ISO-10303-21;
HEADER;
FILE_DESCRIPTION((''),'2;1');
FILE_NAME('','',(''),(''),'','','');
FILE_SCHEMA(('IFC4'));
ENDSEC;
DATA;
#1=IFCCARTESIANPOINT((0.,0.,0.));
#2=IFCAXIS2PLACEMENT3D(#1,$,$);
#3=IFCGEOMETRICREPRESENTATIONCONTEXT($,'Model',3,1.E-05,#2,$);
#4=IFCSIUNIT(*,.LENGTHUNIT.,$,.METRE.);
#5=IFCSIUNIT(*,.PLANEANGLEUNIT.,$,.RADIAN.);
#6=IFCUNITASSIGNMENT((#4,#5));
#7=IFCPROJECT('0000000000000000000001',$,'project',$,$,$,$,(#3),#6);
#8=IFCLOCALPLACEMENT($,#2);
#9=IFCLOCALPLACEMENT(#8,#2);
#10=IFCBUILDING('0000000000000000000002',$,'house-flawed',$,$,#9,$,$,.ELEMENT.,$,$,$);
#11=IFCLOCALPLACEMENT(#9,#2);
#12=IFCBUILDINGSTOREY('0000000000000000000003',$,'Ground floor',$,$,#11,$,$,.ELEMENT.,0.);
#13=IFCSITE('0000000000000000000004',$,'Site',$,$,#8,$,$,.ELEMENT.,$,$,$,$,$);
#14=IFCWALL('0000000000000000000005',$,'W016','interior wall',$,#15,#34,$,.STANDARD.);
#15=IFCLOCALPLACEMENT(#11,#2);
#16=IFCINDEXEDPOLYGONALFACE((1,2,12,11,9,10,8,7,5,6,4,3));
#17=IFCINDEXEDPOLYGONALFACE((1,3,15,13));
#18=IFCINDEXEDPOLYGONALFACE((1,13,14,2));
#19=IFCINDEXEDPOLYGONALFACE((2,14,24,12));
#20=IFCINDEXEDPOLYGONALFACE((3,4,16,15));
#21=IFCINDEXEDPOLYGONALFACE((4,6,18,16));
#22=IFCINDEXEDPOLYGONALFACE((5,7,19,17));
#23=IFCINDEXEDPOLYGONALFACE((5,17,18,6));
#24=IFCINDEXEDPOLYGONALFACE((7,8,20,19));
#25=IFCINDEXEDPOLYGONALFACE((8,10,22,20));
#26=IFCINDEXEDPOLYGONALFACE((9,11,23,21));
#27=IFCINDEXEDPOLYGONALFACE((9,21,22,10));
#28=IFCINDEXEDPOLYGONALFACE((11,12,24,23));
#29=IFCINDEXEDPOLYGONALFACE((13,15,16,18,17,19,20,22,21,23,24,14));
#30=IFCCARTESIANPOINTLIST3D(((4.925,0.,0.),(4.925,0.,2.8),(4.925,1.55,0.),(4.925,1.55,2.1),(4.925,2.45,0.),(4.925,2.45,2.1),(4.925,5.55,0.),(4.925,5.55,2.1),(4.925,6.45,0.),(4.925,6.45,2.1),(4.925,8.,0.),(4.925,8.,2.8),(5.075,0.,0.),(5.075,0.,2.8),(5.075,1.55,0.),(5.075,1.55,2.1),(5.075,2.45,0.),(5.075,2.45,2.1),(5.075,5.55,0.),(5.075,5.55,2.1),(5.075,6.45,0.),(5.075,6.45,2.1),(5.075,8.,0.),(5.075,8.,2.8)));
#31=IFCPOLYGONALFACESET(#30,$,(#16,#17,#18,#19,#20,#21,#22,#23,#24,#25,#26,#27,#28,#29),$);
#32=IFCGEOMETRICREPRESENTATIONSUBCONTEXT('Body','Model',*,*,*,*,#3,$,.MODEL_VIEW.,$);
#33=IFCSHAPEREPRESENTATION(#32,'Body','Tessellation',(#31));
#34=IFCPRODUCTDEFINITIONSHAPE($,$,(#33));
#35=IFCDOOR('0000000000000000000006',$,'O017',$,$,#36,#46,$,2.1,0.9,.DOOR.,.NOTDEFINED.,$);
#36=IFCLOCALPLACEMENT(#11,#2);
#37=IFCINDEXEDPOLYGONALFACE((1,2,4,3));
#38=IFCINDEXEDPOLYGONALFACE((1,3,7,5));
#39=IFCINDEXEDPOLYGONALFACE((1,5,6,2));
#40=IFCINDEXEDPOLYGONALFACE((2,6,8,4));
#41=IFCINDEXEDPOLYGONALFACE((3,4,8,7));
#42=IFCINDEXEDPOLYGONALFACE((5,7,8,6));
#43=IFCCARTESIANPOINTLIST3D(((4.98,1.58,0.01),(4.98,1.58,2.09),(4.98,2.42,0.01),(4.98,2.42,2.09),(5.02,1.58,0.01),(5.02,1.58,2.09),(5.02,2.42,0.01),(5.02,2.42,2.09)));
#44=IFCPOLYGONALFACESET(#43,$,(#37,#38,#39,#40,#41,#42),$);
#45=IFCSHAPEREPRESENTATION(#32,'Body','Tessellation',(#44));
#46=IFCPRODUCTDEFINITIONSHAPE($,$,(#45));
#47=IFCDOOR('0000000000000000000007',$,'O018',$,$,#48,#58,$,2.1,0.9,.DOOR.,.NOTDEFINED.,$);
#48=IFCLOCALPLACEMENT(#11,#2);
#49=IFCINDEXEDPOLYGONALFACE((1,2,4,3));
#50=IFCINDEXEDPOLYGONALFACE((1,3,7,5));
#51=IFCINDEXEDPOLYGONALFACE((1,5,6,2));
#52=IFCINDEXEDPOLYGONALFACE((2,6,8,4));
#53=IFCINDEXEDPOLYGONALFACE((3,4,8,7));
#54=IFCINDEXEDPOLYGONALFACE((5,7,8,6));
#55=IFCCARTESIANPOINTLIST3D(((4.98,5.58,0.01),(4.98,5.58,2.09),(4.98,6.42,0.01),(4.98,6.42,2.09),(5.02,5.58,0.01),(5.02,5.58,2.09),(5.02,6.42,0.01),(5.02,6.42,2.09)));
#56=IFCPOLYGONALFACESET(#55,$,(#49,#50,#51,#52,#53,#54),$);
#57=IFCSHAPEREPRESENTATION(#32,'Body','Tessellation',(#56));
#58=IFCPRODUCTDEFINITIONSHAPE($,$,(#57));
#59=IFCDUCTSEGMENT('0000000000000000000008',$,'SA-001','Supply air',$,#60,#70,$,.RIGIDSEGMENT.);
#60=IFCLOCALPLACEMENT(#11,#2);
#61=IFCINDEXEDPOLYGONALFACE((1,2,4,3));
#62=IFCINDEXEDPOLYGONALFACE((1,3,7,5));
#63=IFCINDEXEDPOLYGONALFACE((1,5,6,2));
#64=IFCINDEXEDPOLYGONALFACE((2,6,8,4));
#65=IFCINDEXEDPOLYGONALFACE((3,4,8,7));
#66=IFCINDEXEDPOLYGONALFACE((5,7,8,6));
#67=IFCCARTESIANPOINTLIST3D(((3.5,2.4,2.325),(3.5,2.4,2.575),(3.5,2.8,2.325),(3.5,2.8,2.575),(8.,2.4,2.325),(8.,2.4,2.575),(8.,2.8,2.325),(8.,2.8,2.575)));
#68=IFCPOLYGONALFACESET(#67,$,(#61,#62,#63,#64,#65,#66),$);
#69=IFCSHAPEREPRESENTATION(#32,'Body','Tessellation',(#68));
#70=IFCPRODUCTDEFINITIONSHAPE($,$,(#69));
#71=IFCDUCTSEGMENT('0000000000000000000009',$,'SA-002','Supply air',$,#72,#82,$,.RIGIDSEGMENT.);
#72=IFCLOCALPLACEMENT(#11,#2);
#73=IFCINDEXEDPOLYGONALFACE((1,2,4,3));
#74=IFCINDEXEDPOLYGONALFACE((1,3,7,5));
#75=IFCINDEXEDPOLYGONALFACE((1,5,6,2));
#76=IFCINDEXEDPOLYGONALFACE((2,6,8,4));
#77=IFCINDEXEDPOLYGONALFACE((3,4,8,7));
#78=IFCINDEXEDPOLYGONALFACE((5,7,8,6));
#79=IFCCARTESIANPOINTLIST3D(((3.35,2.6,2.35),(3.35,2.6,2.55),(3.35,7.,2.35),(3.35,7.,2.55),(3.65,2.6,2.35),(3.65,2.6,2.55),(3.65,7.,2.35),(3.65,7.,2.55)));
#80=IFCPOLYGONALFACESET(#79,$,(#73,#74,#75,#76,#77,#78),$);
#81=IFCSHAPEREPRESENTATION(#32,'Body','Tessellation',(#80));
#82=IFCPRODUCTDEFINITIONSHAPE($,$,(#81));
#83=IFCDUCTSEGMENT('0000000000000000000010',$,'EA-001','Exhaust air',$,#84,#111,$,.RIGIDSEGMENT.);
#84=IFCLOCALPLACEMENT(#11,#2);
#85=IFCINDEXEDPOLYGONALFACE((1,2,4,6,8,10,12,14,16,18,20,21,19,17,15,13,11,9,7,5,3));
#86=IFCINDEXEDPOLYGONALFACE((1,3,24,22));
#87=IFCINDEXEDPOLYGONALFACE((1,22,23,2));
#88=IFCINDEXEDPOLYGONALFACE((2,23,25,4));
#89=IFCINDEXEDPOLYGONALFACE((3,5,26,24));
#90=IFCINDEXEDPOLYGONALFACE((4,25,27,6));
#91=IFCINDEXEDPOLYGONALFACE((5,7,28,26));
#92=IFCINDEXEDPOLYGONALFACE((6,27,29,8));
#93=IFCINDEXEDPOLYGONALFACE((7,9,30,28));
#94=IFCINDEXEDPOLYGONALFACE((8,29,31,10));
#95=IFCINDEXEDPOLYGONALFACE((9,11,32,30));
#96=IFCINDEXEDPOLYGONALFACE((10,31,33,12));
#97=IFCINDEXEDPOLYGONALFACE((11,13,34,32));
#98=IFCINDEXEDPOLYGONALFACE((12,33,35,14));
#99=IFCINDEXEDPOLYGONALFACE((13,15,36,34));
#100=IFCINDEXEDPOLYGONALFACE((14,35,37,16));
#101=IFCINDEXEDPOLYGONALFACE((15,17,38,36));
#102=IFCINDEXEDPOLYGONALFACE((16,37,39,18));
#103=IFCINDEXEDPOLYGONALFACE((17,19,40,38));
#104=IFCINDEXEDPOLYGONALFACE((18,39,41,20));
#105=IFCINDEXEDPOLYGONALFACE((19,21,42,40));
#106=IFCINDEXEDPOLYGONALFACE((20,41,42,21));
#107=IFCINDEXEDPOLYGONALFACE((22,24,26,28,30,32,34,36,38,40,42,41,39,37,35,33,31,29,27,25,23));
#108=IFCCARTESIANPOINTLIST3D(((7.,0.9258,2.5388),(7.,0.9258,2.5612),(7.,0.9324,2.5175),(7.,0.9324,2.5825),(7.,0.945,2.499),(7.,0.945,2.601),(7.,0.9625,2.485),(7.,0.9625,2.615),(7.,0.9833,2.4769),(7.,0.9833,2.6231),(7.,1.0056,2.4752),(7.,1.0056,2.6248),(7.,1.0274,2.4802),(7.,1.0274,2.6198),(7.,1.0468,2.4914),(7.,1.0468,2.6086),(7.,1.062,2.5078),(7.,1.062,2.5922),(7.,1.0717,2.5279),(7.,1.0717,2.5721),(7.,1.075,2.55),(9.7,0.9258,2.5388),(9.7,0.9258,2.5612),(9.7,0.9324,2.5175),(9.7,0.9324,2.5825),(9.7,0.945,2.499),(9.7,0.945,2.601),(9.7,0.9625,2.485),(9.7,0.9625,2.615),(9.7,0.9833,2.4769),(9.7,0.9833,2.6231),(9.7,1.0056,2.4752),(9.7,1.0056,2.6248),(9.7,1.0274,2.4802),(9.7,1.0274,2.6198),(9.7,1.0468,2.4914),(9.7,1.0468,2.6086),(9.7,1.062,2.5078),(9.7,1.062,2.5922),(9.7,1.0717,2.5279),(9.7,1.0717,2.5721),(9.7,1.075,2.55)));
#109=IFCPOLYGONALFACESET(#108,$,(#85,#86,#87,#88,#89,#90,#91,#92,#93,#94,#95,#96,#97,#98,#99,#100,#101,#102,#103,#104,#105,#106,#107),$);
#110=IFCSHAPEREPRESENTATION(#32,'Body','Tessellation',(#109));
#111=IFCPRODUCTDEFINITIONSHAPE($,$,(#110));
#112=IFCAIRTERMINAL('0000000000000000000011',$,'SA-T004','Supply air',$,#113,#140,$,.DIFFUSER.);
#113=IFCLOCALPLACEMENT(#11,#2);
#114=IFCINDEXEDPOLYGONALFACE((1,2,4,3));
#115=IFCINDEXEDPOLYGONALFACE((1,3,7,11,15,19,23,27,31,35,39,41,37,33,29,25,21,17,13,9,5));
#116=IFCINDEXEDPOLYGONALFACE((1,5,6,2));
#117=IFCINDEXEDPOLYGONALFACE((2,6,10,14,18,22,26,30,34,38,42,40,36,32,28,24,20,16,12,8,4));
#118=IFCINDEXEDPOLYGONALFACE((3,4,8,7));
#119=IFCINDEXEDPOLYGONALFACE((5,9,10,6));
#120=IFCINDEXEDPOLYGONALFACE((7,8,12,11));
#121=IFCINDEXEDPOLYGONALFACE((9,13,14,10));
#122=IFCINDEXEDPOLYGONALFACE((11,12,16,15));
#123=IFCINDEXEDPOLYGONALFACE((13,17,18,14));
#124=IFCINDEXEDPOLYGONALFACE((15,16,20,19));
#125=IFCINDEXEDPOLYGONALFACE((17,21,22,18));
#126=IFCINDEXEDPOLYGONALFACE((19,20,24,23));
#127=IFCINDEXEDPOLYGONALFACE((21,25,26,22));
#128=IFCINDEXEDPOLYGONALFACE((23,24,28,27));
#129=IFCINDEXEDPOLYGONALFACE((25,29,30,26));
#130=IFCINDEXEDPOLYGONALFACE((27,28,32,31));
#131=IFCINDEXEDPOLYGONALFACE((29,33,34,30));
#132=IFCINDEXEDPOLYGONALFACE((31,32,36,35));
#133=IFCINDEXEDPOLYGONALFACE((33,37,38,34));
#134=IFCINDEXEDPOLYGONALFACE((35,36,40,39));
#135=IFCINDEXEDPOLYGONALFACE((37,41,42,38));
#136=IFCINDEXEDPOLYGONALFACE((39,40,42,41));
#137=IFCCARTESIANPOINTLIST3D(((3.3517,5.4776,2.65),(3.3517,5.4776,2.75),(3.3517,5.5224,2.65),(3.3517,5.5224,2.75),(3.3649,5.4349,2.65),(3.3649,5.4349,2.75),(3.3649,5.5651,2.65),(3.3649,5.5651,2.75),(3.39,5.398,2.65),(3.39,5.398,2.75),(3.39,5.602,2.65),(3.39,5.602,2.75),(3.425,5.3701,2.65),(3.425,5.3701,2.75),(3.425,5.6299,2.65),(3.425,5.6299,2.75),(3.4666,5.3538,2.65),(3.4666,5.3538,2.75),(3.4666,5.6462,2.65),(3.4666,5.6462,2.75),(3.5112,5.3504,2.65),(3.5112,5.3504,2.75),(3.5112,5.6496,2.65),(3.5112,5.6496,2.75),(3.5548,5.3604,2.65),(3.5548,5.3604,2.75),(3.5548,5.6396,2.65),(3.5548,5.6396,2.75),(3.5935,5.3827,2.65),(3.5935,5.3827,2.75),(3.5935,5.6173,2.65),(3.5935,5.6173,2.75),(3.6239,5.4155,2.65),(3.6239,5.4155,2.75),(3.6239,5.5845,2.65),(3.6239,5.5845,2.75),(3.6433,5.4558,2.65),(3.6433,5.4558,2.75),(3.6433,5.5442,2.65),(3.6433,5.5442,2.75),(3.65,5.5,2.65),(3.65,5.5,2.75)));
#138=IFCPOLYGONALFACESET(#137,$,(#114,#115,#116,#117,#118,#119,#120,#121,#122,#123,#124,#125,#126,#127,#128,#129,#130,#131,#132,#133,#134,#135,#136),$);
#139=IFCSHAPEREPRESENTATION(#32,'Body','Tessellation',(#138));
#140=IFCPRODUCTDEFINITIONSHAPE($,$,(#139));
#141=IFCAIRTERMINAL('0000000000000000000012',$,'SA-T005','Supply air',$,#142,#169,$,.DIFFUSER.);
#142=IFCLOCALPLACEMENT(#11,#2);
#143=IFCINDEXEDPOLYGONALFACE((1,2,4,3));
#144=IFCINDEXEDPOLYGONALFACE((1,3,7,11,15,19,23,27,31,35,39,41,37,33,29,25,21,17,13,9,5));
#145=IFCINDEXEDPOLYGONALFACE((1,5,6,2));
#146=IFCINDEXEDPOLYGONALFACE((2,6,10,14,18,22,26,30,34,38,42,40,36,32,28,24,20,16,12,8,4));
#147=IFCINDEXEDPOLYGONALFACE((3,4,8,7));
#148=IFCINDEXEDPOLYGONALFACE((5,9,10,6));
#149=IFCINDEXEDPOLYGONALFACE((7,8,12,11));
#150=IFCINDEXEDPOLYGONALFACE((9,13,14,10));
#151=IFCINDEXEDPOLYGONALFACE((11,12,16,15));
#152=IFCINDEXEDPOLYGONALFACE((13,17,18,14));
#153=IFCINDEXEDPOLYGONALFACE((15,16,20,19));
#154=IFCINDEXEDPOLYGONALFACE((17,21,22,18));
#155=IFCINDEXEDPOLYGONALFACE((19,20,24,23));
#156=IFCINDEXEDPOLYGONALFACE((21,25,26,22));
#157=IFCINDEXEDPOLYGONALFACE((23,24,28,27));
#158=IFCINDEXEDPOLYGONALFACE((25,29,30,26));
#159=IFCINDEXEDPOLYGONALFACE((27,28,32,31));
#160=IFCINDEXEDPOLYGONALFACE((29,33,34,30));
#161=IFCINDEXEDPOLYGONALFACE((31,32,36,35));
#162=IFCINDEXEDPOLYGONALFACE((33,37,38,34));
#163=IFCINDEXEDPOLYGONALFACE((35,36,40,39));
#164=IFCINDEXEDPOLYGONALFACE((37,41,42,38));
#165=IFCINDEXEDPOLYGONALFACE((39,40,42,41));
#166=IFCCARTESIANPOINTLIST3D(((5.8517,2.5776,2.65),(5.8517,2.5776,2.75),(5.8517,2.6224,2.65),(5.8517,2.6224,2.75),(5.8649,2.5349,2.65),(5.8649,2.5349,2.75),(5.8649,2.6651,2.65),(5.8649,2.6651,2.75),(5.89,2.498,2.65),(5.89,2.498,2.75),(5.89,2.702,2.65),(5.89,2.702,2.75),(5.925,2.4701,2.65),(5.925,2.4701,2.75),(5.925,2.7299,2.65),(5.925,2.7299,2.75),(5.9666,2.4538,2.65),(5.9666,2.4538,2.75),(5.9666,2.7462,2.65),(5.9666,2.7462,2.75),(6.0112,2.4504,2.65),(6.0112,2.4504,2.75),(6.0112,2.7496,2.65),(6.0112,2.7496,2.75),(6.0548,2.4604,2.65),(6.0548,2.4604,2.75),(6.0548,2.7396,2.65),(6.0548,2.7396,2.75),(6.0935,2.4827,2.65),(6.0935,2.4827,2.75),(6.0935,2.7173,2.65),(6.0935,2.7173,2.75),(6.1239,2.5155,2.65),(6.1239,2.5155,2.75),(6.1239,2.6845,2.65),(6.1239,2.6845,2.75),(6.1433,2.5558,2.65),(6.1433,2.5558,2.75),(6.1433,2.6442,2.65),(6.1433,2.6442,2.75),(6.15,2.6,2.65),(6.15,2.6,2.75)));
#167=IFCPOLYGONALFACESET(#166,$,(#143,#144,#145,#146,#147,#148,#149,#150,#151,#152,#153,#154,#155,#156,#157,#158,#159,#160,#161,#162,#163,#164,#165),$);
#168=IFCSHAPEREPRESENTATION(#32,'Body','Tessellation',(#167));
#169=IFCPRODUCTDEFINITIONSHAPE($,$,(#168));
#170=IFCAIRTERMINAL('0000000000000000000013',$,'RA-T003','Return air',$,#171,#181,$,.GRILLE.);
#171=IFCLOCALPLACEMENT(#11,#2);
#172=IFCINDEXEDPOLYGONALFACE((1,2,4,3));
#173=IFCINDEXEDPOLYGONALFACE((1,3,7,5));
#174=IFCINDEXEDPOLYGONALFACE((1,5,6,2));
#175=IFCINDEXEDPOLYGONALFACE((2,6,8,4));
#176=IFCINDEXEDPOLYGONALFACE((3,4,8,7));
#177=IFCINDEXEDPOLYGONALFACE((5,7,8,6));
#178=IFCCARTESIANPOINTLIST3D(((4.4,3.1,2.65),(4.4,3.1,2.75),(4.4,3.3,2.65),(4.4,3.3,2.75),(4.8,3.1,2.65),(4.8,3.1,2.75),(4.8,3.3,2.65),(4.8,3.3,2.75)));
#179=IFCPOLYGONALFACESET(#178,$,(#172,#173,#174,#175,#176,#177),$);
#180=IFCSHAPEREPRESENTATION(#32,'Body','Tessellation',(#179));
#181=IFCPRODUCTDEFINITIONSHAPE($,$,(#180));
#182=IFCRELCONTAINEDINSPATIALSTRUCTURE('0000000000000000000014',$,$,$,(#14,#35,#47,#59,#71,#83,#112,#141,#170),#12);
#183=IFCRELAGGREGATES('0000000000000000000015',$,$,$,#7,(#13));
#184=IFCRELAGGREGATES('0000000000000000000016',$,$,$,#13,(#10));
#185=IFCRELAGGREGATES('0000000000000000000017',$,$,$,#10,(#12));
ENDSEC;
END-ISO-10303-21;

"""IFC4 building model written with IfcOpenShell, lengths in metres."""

from ifc_helpers import new_model, si_unit, frame, origin, origin_2d, place, context, subcontext, project, spatial, rectangle, circle, extrude, element, fill, save


model = new_model("IFC4")

# Units and contexts
model_context = context("Model", 3, precision=1e-05, world=origin())
body_context = subcontext(model_context, "Body", "Model", "MODEL_VIEW")
ifc_project = project(units=[si_unit("LENGTHUNIT", "METRE"), si_unit("PLANEANGLEUNIT", "RADIAN")], contexts=[model_context])

# Site, building, storey
site_placement = place(None, origin())
site = spatial("IfcSite", under=ifc_project, at=site_placement, Name="Site", CompositionType="ELEMENT")
building_placement = place(site_placement, origin())
building = spatial("IfcBuilding", under=site, at=building_placement, Name="house-flawed", CompositionType="ELEMENT")
storey_placement = place(building_placement, origin())
storey = spatial("IfcBuildingStorey", under=building, at=storey_placement, Name="Ground floor", CompositionType="ELEMENT", Elevation=0.0)

# Wall, openings, doors
wall_1_placement = place(storey_placement, frame((5.0, 4.0, 0.0), z_axis=(0.0, 0.0, 1.0), x_axis=(0.0, 1.0, 0.0)))
wall_1 = element("IfcWall", 1, at=wall_1_placement, inside=storey, Name="W016", Description="interior wall", PredefinedType="STANDARD", context=body_context, shape_type="SweptSolid", body=[
    extrude(rectangle(XDim=8.0, YDim=0.15, at=origin_2d()), origin(), (0.0, 0.0, 1.0), 2.8),
])
opening_1_placement = place(wall_1_placement, frame((-2.0, 0.0, 0.0)))
opening_1 = element("IfcOpeningElement", 2, at=opening_1_placement, cuts=wall_1, PredefinedType="OPENING", context=body_context, shape_type="SweptSolid", body=[
    extrude(rectangle(XDim=0.9, YDim=0.18, at=origin_2d()), origin(), (0.0, 0.0, 1.0), 2.1),
])
opening_2_placement = place(wall_1_placement, frame((2.0, 0.0, 0.0)))
opening_2 = element("IfcOpeningElement", 3, at=opening_2_placement, cuts=wall_1, PredefinedType="OPENING", context=body_context, shape_type="SweptSolid", body=[
    extrude(rectangle(XDim=0.9, YDim=0.18, at=origin_2d()), origin(), (0.0, 0.0, 1.0), 2.1),
])
door_1_placement = place(wall_1_placement, frame((-2.0, 0.0, 0.0)))
door_1 = element("IfcDoor", 4, at=door_1_placement, inside=storey, Name="O017", OperationType="NOTDEFINED", OverallHeight=2.1, OverallWidth=0.9, PredefinedType="DOOR", context=body_context, shape_type="SweptSolid", body=[
    extrude(rectangle(XDim=0.84, YDim=0.04, at=origin_2d()), frame((0.0, 0.0, 0.01)), (0.0, 0.0, 1.0), 2.08),
])
fill(opening_1, door_1)
door_2_placement = place(wall_1_placement, frame((2.0, 0.0, 0.0)))
door_2 = element("IfcDoor", 5, at=door_2_placement, inside=storey, Name="O018", OperationType="NOTDEFINED", OverallHeight=2.1, OverallWidth=0.9, PredefinedType="DOOR", context=body_context, shape_type="SweptSolid", body=[
    extrude(rectangle(XDim=0.84, YDim=0.04, at=origin_2d()), frame((0.0, 0.0, 0.01)), (0.0, 0.0, 1.0), 2.08),
])
fill(opening_2, door_2)

# Duct segments
duct_segment_1_placement = place(storey_placement, frame((3.5, 2.6, 2.45), z_axis=(1.0, 0.0, 0.0), x_axis=(0.0, 1.0, 0.0)))
element("IfcDuctSegment", 6, at=duct_segment_1_placement, inside=storey, Name="SA-001", Description="Supply air", PredefinedType="RIGIDSEGMENT", context=body_context, shape_type="SweptSolid", body=[
    extrude(rectangle(XDim=0.4, YDim=0.25, at=origin_2d()), origin(), (0.0, 0.0, 1.0), 4.5),
])
duct_segment_2_placement = place(storey_placement, frame((3.5, 2.6, 2.45), z_axis=(0.0, 1.0, 0.0), x_axis=(-1.0, 0.0, 0.0)))
element("IfcDuctSegment", 7, at=duct_segment_2_placement, inside=storey, Name="SA-002", Description="Supply air", PredefinedType="RIGIDSEGMENT", context=body_context, shape_type="SweptSolid", body=[
    extrude(rectangle(XDim=0.3, YDim=0.2, at=origin_2d()), origin(), (0.0, 0.0, 1.0), 4.4),
])
duct_segment_3_placement = place(storey_placement, frame((7.0, 1.0, 2.55), z_axis=(1.0, 0.0, 0.0), x_axis=(0.0, 1.0, 0.0)))
element("IfcDuctSegment", 8, at=duct_segment_3_placement, inside=storey, Name="EA-001", Description="Exhaust air", PredefinedType="RIGIDSEGMENT", context=body_context, shape_type="SweptSolid", body=[
    extrude(circle(Radius=0.075, at=origin_2d()), origin(), (0.0, 0.0, 1.0), 2.7),
])

# Air terminals
for number, where, z_axis, x_axis, name in (
    (9, (3.5, 5.5, 2.65), (0.0, 0.0, 1.0), (1.0, 0.0, 0.0), "SA-T004"),
    (10, (6.0, 2.6, 2.65), (0.0, 0.0, 1.0), (1.0, 0.0, 0.0), "SA-T005"),
):
    element("IfcAirTerminal", number, at=place(storey_placement, frame(where, z_axis=z_axis, x_axis=x_axis)), inside=storey, Name=name, Description="Supply air", PredefinedType="DIFFUSER", context=body_context, shape_type="SweptSolid", body=[
        extrude(circle(Radius=0.15, at=origin_2d()), origin(), (0.0, 0.0, 1.0), 0.1),
    ])
air_terminal_placement = place(storey_placement, frame((4.6, 3.2, 2.65), z_axis=(0.0, 0.0, 1.0), x_axis=(1.0, 0.0, 0.0)))
element("IfcAirTerminal", 11, at=air_terminal_placement, inside=storey, Name="RA-T003", Description="Return air", PredefinedType="GRILLE", context=body_context, shape_type="SweptSolid", body=[
    extrude(rectangle(XDim=0.4, YDim=0.2, at=origin_2d()), origin(), (0.0, 0.0, 1.0), 0.1),
])

save(model, "model.ifc")
